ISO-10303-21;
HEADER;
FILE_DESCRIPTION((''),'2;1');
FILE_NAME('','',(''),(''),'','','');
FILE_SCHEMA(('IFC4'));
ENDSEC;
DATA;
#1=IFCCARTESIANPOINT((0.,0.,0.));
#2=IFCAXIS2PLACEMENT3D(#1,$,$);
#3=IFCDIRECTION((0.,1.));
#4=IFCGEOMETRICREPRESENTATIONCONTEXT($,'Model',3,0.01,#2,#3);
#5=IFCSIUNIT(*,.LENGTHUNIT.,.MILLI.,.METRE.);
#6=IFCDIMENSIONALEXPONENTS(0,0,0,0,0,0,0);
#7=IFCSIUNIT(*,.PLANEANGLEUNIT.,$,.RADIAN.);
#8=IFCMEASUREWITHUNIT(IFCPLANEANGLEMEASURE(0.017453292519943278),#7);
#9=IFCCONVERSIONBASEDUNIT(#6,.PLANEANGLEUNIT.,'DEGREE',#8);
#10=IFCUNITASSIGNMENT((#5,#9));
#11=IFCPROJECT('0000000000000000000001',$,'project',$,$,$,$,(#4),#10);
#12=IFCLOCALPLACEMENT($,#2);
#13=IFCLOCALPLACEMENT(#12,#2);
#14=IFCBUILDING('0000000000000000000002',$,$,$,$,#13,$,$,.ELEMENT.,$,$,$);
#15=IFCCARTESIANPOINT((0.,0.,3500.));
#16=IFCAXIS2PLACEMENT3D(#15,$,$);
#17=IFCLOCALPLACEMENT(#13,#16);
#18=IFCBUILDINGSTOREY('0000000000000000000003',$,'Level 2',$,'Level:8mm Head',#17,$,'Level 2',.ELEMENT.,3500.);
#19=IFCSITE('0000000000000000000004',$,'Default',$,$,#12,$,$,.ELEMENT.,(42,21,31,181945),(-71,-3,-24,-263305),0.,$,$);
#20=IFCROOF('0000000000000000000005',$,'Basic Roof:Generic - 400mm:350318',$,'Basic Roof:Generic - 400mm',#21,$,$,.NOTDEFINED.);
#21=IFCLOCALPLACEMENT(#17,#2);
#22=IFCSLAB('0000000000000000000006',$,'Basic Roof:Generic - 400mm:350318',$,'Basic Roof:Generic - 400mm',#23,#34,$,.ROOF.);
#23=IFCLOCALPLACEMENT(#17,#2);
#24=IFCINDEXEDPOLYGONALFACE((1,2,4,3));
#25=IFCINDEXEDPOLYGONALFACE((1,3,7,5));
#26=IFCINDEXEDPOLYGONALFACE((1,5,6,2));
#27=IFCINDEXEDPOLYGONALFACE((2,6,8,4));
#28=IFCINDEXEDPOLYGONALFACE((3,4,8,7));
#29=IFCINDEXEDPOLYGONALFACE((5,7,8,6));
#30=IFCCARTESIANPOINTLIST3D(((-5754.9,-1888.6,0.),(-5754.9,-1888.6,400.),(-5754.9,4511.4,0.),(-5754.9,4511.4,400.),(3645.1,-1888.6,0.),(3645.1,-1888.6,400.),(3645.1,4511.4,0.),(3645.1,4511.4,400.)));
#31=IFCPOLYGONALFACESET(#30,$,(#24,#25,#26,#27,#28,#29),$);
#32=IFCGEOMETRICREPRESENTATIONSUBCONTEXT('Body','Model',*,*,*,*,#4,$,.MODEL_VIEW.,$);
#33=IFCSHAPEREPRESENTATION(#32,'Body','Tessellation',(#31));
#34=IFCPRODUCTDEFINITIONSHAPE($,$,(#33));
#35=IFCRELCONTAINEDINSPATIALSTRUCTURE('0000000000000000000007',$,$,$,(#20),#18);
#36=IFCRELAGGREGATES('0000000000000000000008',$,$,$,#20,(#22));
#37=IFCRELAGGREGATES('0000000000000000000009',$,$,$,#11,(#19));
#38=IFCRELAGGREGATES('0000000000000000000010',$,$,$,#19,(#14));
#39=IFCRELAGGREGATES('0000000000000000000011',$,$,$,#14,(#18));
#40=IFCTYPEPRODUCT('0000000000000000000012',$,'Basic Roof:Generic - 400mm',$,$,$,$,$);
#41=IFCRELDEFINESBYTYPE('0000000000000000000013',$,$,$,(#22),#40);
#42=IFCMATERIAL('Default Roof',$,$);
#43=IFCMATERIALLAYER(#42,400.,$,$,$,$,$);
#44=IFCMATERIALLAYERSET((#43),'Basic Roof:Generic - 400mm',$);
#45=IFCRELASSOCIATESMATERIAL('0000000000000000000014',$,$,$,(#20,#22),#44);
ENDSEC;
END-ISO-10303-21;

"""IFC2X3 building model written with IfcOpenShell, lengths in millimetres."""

from ifc_helpers import new_model, entity, si_unit, converted_unit, direction, frame, frame_2d, origin, place, context, subcontext, project, spatial, rectangle, extrude, material, layer, layer_set, type_object, element, aggregate, save


model = new_model("IFC2X3")

# Units and contexts
model_context = context("Model", 3, precision=0.01, world=origin(), true_north=direction((0.0, 1.0)))
body_context = subcontext(model_context, "Body", "Model", "MODEL_VIEW")
ifc_project = project(units=[si_unit("LENGTHUNIT", "METRE", prefix="MILLI"), converted_unit("PLANEANGLEUNIT", "DEGREE", entity("IfcPlaneAngleMeasure", 0.017453292519943278), si_unit("PLANEANGLEUNIT", "RADIAN"), dimensions=[0, 0, 0, 0, 0, 0, 0])], contexts=[model_context])

# Site, building, storey
site_placement = place(None, origin())
site = spatial("IfcSite", under=ifc_project, at=site_placement, Name="Default", CompositionType="ELEMENT", RefLatitude=(42, 21, 31, 181945), RefLongitude=(-71, -3, -24, -263305), RefElevation=0.0)
building_placement = place(site_placement, origin())
building = spatial("IfcBuilding", under=site, at=building_placement, CompositionType="ELEMENT")
storey_placement = place(building_placement, frame((0.0, 0.0, 3500.0)))
storey = spatial("IfcBuildingStorey", under=building, at=storey_placement, Name="Level 2", ObjectType="Level:8mm Head", LongName="Level 2", CompositionType="ELEMENT", Elevation=3500.0)

# Roof, slab
ifc_material = material(Name="Default Roof")
ifc_layer = layer(ifc_material, 400.0)
ifc_layer_set = layer_set([ifc_layer], Name="Basic Roof:Generic - 400mm")
roof_placement = place(storey_placement, frame((-5754.9, -1888.6, 0.0)))
roof = element("IfcRoof", 1, at=roof_placement, inside=storey, material=ifc_layer_set, Name="Basic Roof:Generic - 400mm:350318", ObjectType="Basic Roof:Generic - 400mm", ShapeType="NOTDEFINED")
type_product = type_object("IfcTypeProduct", Name="Basic Roof:Generic - 400mm")
slab_placement = place(roof_placement, origin())
slab = element("IfcSlab", 2, at=slab_placement, type_object=type_product, material=ifc_layer_set, Name="Basic Roof:Generic - 400mm:350318", ObjectType="Basic Roof:Generic - 400mm", PredefinedType="ROOF", context=body_context, shape_type="SweptSolid", body=[
    extrude(rectangle(XDim=9400.0, YDim=6400.0, at=frame_2d((0.0, 0.0), x_axis=(1.0, 0.0))), frame((4700.0, 3200.0, 0.0)), (0.0, 0.0, 1.0), 400.0),
])
aggregate(roof, [slab])

save(model, "model.ifc")
